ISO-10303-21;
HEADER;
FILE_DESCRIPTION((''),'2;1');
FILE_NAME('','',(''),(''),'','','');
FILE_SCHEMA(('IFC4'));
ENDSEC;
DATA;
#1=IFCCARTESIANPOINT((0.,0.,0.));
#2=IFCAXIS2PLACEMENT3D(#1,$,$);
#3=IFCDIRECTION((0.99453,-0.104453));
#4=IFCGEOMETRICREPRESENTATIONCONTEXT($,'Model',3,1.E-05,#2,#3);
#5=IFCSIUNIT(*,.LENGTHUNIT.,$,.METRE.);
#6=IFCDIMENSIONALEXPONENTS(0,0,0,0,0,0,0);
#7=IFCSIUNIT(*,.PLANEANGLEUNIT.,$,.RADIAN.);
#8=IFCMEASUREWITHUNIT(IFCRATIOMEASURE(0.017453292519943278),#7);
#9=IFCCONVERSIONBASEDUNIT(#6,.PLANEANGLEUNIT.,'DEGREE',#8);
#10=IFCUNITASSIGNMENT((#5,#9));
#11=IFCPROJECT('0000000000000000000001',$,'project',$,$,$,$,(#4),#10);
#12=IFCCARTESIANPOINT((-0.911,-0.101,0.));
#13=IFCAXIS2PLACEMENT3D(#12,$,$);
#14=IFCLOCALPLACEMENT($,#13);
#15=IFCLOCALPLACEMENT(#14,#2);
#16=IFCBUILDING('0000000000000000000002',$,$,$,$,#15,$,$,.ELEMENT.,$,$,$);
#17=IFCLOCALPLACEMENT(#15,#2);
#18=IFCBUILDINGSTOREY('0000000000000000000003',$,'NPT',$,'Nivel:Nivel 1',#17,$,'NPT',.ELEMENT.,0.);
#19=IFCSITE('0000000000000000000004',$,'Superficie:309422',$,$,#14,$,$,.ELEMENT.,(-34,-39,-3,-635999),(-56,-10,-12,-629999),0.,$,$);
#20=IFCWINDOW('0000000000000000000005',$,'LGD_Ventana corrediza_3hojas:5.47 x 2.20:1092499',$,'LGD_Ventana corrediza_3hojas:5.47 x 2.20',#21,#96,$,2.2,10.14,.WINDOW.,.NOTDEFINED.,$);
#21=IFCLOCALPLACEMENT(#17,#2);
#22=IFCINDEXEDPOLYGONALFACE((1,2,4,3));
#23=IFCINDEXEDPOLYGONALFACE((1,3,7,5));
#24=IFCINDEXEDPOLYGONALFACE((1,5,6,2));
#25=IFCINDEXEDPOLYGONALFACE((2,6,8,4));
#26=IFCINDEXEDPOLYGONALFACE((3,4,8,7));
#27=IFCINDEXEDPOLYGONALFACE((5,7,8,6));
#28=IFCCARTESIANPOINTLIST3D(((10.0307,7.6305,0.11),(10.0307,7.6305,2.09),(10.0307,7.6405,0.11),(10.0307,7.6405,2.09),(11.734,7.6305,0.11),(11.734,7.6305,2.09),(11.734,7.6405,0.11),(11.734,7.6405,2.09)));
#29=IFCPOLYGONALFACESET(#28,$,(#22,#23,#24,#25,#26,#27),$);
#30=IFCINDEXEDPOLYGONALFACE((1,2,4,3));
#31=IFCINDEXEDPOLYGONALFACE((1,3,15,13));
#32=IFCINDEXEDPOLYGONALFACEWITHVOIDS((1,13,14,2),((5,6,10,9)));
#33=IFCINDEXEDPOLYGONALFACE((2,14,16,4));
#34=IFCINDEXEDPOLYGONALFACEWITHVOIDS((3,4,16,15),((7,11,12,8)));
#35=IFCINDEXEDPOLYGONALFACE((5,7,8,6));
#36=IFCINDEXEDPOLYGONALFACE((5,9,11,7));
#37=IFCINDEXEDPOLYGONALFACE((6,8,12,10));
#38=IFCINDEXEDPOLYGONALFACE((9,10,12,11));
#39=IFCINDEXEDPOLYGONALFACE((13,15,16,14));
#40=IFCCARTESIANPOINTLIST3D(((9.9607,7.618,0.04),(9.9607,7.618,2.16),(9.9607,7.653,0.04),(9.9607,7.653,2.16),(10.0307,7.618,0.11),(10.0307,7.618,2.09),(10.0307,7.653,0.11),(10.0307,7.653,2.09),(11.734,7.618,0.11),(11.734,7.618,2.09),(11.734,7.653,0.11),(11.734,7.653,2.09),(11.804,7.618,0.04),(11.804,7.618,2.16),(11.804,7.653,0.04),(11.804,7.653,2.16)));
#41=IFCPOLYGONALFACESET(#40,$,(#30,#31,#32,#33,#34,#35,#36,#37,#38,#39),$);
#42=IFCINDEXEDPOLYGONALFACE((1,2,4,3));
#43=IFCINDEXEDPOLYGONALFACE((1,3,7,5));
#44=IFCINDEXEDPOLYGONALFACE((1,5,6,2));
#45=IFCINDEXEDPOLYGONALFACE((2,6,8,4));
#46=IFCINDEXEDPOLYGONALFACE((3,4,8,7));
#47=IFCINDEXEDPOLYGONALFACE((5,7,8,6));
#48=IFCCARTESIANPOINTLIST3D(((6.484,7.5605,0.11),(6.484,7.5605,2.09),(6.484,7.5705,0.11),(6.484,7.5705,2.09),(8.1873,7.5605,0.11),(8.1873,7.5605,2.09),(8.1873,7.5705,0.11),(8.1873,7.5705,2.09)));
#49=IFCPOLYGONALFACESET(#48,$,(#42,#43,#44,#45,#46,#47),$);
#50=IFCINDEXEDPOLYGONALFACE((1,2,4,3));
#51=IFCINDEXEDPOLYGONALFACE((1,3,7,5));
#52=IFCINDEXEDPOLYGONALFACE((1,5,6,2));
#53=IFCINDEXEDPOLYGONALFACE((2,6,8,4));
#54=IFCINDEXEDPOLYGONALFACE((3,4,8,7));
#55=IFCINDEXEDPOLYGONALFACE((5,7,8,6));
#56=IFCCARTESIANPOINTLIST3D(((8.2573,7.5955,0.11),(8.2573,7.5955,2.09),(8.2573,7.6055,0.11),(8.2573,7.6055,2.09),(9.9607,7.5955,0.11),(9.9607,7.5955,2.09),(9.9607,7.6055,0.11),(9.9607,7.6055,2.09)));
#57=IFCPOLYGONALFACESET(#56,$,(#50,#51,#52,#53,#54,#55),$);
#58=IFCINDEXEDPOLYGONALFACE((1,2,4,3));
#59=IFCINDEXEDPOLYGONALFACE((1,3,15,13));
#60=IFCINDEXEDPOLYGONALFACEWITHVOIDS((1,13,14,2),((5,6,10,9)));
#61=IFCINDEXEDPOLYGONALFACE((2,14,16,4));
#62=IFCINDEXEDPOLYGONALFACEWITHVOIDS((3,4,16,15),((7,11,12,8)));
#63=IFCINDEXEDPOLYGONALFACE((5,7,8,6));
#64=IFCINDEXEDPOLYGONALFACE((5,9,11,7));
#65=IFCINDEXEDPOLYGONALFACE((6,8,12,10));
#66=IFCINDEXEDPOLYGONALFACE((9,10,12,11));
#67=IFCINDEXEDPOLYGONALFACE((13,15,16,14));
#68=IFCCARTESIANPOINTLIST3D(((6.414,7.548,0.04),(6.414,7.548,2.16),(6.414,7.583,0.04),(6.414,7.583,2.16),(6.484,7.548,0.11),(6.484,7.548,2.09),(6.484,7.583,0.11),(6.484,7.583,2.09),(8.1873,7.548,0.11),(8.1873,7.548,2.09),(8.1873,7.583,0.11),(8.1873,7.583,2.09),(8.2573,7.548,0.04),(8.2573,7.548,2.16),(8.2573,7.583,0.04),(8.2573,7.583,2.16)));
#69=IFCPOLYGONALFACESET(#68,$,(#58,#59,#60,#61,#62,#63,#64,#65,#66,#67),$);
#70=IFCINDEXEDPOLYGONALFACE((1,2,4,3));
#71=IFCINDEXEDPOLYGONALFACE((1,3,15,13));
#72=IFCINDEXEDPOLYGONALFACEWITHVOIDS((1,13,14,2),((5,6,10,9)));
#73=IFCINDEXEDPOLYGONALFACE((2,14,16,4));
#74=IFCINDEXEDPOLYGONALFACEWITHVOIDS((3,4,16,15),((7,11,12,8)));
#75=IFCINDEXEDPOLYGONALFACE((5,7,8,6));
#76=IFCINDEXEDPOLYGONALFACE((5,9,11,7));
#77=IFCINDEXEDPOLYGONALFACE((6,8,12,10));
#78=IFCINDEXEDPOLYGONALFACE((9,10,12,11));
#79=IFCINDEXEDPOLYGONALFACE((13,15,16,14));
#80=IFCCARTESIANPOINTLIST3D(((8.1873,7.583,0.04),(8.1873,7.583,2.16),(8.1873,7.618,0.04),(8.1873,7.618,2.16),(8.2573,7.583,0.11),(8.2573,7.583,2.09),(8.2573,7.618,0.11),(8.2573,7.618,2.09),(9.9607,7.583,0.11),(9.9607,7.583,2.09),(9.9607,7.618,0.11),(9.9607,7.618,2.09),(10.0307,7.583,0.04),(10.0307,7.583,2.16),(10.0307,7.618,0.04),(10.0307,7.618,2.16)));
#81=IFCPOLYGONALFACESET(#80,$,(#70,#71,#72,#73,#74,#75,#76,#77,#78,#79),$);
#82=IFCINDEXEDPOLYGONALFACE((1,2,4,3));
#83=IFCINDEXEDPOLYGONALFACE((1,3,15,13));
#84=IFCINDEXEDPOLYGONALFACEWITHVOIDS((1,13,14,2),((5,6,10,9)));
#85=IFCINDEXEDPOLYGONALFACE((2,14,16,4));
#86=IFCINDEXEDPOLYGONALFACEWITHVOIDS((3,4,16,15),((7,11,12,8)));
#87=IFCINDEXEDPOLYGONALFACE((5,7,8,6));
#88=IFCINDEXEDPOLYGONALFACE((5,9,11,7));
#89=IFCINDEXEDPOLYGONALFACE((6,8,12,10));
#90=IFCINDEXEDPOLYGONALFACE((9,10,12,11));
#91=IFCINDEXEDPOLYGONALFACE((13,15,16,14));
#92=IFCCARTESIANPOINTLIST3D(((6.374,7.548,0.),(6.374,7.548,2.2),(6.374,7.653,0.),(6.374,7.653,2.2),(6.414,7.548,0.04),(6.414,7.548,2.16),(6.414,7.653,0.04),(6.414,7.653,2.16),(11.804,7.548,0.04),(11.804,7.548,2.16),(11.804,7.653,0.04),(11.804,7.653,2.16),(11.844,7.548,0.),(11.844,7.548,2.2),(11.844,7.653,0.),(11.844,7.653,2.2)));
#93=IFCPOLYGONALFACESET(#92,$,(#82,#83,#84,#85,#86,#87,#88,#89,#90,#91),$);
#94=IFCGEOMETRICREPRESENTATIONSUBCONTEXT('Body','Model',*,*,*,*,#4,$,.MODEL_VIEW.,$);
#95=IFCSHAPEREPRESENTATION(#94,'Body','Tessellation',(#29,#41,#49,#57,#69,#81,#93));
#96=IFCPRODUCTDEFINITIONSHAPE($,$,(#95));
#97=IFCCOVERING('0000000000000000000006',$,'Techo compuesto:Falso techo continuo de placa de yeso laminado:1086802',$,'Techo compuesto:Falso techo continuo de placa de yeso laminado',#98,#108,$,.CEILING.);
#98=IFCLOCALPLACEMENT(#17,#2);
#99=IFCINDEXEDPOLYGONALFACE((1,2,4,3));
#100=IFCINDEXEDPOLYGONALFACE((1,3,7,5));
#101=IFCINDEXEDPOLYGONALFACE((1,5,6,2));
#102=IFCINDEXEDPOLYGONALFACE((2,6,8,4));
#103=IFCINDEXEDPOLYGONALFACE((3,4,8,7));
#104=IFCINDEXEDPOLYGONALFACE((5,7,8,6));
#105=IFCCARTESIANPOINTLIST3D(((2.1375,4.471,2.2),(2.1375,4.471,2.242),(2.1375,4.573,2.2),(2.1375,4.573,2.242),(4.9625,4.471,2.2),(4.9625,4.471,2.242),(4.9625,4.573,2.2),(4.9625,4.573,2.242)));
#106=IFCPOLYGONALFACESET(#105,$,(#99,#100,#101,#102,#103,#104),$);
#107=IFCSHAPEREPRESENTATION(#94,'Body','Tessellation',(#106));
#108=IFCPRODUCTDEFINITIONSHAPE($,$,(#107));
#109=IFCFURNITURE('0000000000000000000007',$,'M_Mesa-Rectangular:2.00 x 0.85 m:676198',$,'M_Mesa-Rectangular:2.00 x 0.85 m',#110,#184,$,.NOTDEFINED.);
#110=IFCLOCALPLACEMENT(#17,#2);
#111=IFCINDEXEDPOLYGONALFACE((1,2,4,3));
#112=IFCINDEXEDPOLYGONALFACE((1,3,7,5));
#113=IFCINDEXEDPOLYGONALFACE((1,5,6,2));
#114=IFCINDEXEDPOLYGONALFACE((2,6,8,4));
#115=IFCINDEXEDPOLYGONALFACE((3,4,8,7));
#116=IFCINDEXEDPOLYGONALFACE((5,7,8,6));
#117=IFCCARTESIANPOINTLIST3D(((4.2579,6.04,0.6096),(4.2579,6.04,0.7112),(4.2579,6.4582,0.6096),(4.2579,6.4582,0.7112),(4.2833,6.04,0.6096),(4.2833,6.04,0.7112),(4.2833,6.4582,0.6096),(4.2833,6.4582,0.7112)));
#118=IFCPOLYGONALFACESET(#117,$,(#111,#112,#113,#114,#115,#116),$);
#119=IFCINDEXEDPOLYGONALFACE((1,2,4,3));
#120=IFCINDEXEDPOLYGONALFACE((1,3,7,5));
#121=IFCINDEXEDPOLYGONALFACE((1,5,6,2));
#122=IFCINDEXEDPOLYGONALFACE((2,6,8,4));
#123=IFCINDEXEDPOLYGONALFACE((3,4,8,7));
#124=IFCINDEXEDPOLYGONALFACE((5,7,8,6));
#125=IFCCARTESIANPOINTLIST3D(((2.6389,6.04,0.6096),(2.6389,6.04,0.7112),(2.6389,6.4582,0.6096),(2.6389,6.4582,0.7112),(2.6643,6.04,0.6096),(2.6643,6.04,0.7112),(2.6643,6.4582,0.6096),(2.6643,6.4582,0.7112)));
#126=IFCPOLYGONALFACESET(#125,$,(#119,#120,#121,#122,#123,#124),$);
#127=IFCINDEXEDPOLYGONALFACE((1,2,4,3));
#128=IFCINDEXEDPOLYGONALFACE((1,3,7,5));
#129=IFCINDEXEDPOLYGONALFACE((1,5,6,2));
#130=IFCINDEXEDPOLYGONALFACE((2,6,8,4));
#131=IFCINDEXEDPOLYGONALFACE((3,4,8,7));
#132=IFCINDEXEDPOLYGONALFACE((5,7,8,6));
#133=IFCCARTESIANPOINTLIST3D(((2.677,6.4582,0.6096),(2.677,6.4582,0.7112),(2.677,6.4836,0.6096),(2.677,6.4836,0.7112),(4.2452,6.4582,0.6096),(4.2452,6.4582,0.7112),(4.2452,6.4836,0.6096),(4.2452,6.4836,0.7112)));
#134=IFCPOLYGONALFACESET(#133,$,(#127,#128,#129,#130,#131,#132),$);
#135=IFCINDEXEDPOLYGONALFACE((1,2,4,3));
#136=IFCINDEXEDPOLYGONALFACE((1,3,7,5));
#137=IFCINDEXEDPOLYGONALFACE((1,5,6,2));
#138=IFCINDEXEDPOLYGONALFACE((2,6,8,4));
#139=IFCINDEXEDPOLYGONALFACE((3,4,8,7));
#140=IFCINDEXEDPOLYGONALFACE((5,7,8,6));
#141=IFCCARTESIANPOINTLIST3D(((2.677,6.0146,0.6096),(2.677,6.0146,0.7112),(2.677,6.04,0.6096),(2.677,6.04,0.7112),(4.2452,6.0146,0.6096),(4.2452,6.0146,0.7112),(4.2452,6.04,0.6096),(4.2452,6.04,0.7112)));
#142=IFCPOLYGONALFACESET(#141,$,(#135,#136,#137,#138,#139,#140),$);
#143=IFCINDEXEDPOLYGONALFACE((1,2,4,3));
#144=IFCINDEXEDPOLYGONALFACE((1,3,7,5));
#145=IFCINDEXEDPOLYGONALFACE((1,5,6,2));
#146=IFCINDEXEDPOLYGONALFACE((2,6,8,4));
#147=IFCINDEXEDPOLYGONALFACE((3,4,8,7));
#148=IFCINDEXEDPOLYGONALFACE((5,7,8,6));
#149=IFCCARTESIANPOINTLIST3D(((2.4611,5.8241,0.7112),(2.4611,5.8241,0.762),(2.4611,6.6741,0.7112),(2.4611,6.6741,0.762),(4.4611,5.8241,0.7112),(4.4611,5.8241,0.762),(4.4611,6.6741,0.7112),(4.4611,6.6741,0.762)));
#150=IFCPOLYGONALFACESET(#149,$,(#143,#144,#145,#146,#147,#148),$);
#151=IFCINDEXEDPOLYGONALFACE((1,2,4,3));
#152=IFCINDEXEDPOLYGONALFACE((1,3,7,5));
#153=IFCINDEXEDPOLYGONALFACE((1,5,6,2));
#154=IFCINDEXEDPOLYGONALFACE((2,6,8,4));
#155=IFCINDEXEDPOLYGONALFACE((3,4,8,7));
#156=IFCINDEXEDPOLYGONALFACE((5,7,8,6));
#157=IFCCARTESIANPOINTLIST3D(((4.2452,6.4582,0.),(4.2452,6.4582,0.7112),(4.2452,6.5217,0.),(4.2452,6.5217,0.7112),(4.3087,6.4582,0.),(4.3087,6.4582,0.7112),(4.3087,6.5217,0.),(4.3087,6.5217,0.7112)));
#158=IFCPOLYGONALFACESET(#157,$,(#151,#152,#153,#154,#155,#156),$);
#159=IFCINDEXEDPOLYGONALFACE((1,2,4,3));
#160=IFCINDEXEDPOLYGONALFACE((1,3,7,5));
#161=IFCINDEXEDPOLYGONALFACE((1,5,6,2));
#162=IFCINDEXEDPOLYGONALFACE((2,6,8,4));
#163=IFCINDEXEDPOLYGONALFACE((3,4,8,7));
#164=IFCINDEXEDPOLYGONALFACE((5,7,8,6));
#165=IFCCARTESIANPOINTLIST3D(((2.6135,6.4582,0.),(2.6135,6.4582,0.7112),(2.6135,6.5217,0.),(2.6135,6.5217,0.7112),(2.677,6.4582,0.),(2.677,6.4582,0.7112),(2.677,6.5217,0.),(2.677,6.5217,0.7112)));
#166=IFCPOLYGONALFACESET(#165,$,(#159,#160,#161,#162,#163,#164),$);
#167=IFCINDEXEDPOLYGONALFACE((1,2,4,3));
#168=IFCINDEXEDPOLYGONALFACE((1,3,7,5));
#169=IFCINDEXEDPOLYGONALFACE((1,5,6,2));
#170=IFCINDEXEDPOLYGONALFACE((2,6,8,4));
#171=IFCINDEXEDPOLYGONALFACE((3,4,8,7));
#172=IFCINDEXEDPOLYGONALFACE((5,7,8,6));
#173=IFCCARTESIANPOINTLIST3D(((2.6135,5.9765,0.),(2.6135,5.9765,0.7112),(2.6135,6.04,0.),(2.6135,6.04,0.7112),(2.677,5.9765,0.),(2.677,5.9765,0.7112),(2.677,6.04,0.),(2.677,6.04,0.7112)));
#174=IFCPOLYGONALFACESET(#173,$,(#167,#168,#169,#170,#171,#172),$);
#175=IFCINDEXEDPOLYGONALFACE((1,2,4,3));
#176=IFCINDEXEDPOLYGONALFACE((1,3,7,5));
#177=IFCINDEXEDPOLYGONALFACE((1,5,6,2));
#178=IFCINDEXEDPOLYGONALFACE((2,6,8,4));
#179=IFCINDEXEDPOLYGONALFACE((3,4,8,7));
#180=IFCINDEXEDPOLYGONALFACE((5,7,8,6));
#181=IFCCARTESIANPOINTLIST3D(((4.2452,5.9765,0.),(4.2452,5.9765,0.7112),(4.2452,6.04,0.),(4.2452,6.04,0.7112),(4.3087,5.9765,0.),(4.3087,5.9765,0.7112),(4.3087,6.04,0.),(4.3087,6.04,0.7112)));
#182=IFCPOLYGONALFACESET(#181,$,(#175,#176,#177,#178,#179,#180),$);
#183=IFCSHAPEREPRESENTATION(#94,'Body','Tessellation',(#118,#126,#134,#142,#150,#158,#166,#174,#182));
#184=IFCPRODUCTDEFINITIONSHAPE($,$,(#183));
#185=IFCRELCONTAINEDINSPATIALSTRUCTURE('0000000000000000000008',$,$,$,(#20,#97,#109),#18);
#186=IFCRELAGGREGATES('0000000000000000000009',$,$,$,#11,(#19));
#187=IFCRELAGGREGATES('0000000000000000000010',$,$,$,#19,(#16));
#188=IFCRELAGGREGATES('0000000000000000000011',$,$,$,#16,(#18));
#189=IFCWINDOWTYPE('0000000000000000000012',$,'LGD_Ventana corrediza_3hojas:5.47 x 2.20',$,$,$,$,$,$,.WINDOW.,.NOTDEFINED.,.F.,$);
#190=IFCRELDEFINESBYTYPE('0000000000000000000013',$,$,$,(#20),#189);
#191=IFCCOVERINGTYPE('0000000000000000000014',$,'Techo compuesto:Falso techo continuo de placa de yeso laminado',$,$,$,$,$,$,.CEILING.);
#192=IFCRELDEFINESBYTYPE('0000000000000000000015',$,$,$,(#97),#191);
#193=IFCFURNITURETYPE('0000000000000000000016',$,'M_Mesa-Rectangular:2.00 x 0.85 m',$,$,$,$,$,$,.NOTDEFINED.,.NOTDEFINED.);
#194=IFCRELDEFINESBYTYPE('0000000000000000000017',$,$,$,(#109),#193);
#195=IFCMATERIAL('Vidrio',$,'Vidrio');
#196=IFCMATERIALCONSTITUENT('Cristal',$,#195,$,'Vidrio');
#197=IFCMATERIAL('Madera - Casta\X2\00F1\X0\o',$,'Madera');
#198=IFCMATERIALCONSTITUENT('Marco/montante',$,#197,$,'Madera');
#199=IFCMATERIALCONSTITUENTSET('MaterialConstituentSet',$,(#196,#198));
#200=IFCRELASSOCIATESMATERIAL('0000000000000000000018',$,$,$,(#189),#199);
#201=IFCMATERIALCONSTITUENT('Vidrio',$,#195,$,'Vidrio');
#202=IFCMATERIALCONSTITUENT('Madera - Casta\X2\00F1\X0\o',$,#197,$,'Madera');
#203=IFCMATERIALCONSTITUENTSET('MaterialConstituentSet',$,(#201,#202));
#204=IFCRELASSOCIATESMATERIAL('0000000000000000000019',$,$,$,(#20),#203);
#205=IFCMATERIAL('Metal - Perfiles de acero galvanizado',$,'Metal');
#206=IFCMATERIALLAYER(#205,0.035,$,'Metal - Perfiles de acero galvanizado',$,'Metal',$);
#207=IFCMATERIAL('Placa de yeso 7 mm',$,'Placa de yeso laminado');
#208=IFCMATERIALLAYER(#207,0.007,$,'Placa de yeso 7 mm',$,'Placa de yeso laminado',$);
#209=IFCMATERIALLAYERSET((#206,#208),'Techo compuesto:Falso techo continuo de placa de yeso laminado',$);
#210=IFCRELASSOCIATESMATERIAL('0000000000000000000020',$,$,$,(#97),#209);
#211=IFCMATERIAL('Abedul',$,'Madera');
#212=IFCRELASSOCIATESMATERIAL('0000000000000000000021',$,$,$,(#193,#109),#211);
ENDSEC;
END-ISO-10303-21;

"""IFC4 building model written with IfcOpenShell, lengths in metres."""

from ifc_helpers import new_model, entity, si_unit, converted_unit, direction, frame, frame_2d, origin, origin_2d_with_axis, place, context, subcontext, project, spatial, polyline, rectangle, outline, extrude, source, transform, mapped, material, layer, layer_set, layer_usage, constituent, constituent_set, type_object, type_shapes, element, save


model = new_model("IFC4")

# Units and contexts
model_context = context("Model", 3, precision=1e-05, world=origin(), true_north=direction((0.99453, -0.104453)))
body_context = subcontext(model_context, "Body", "Model", "MODEL_VIEW")
ifc_project = project(units=[si_unit("LENGTHUNIT", "METRE"), converted_unit("PLANEANGLEUNIT", "DEGREE", entity("IfcRatioMeasure", 0.017453292519943278), si_unit("PLANEANGLEUNIT", "RADIAN"), dimensions=[0, 0, 0, 0, 0, 0, 0])], contexts=[model_context])

# Site, building, storey
site_placement = place(None, frame((-0.911, -0.101, 0.0)))
site = spatial("IfcSite", under=ifc_project, at=site_placement, Name="Superficie:309422", CompositionType="ELEMENT", RefLatitude=(-34, -39, -3, -635999), RefLongitude=(-56, -10, -12, -629999), RefElevation=0.0)
building_placement = place(site_placement, origin())
building = spatial("IfcBuilding", under=site, at=building_placement, CompositionType="ELEMENT")
storey_placement = place(building_placement, origin())
storey = spatial("IfcBuildingStorey", under=building, at=storey_placement, Name="NPT", ObjectType="Nivel:Nivel 1", LongName="NPT", CompositionType="ELEMENT", Elevation=0.0)

# Window
ifc_material_1 = material(Name="Vidrio", Category="Vidrio")
ifc_constituent_1 = constituent(ifc_material_1, Name="Vidrio", Category="Vidrio")
ifc_material_2 = material(Name="Madera - Castaño", Category="Madera")
ifc_constituent_2 = constituent(ifc_material_2, Name="Madera - Castaño", Category="Madera")
ifc_constituent_set_1 = constituent_set(constituents=[ifc_constituent_1, ifc_constituent_2], Name="MaterialConstituentSet")
ifc_constituent_3 = constituent(ifc_material_1, Name="Cristal", Category="Vidrio")
ifc_constituent_4 = constituent(ifc_material_2, Name="Marco/montante", Category="Madera")
ifc_constituent_set_2 = constituent_set(constituents=[ifc_constituent_3, ifc_constituent_4], Name="MaterialConstituentSet")
window_type_1 = type_object("IfcWindowType", Name="LGD_Ventana corrediza_3hojas:5.47 x 2.20", ParameterTakesPrecedence=False, PartitioningType="NOTDEFINED", PredefinedType="WINDOW", material=ifc_constituent_set_2)
shared_shape_1 = source(origin(), body_context, "Body", "SweptSolid", [
    extrude(rectangle(XDim=0.01, YDim=1.7033, at=frame_2d((0.0, 0.0), x_axis=(1.0, 0.0))), frame((6.2817, 0.2175, 0.11), z_axis=(0.0, 0.0, 1.0), x_axis=(0.0, -1.0, 0.0)), (0.0, 0.0, 1.0), 1.98),
    extrude(outline(polyline([(-0.9217, -1.06), (0.9217, -1.06), (0.9217, 1.06), (-0.9217, 1.06), (-0.9217, -1.06)]), holes=[polyline([(-0.8517, 0.99), (0.8517, 0.99), (0.8517, -0.99), (-0.8517, -0.99), (-0.8517, 0.99)])]), frame((6.2817, 0.235, 1.1), z_axis=(0.0, -1.0, 0.0), x_axis=(1.0, 0.0, 0.0)), (0.0, 0.0, 1.0), 0.035),
    extrude(rectangle(XDim=0.01, YDim=1.7033, at=frame_2d((0.0, 0.0), x_axis=(1.0, 0.0))), frame((2.735, 0.1475, 0.11), z_axis=(0.0, 0.0, 1.0), x_axis=(0.0, -1.0, 0.0)), (0.0, 0.0, 1.0), 1.98),
    extrude(rectangle(XDim=0.01, YDim=1.7033, at=frame_2d((0.0, 0.0), x_axis=(1.0, 0.0))), frame((4.5083, 0.1825, 0.11), z_axis=(0.0, 0.0, 1.0), x_axis=(0.0, -1.0, 0.0)), (0.0, 0.0, 1.0), 1.98),
    extrude(outline(polyline([(-0.9217, -1.06), (0.9217, -1.06), (0.9217, 1.06), (-0.9217, 1.06), (-0.9217, -1.06)]), holes=[polyline([(-0.8517, 0.99), (0.8517, 0.99), (0.8517, -0.99), (-0.8517, -0.99), (-0.8517, 0.99)])]), frame((2.735, 0.165, 1.1), z_axis=(0.0, -1.0, 0.0), x_axis=(1.0, 0.0, 0.0)), (0.0, 0.0, 1.0), 0.035),
    extrude(outline(polyline([(-0.9217, -1.06), (0.9217, -1.06), (0.9217, 1.06), (-0.9217, 1.06), (-0.9217, -1.06)]), holes=[polyline([(-0.8517, 0.99), (0.8517, 0.99), (0.8517, -0.99), (-0.8517, -0.99), (-0.8517, 0.99)])]), frame((4.5083, 0.2, 1.1), z_axis=(0.0, -1.0, 0.0), x_axis=(1.0, 0.0, 0.0)), (0.0, 0.0, 1.0), 0.035),
    extrude(outline(polyline([(-2.735, -1.1), (2.735, -1.1), (2.735, 1.1), (-2.735, 1.1), (-2.735, -1.1)]), holes=[polyline([(-2.695, 1.06), (2.695, 1.06), (2.695, -1.06), (-2.695, -1.06), (-2.695, 1.06)])]), frame((4.5083, 0.235, 1.1), z_axis=(0.0, -1.0, 0.0), x_axis=(1.0, 0.0, 0.0)), (0.0, 0.0, 1.0), 0.105),
])
type_shapes(window_type_1, [shared_shape_1])
window_1_placement = place(storey_placement, frame((4.6007, 7.418, 0.0)))
element("IfcWindow", 1, at=window_1_placement, inside=storey, type_object=window_type_1, material=ifc_constituent_set_1, Name="LGD_Ventana corrediza_3hojas:5.47 x 2.20:1092499", ObjectType="LGD_Ventana corrediza_3hojas:5.47 x 2.20", OverallHeight=2.2, OverallWidth=10.14, PartitioningType="NOTDEFINED", PredefinedType="WINDOW", context=body_context, shape_type="MappedRepresentation", body=[
    mapped(shared_shape_1, transform((0.0, 0.0, 0.0), scale=1.0)),
])

# Covering
ifc_material_3 = material(Name="Metal - Perfiles de acero galvanizado", Category="Metal")
ifc_layer_1 = layer(ifc_material_3, 0.035, Name="Metal - Perfiles de acero galvanizado", Category="Metal")
ifc_material_4 = material(Name="Placa de yeso 7 mm", Category="Placa de yeso laminado")
ifc_layer_2 = layer(ifc_material_4, 0.007, Name="Placa de yeso 7 mm", Category="Placa de yeso laminado")
ifc_layer_set_1 = layer_set([ifc_layer_1, ifc_layer_2], Name="Techo compuesto:Falso techo continuo de placa de yeso laminado")
ifc_layer_usage_1 = layer_usage(ifc_layer_set_1, "AXIS3", "POSITIVE", 0.0)
covering_type = type_object("IfcCoveringType", Name="Techo compuesto:Falso techo continuo de placa de yeso laminado", PredefinedType="CEILING")
covering_placement = place(storey_placement, frame((2.1375, 4.471, 2.2)))
element("IfcCovering", 2, at=covering_placement, inside=storey, type_object=covering_type, material=ifc_layer_usage_1, Name="Techo compuesto:Falso techo continuo de placa de yeso laminado:1086802", ObjectType="Techo compuesto:Falso techo continuo de placa de yeso laminado", PredefinedType="CEILING", context=body_context, shape_type="SweptSolid", body=[
    extrude(rectangle(XDim=2.825, YDim=0.102, at=frame_2d((0.0, 0.0), x_axis=(1.0, 0.0))), frame((1.4125, 0.051, 0.0), z_axis=(0.0, 0.0, 1.0), x_axis=(-1.0, 0.0, 0.0)), (0.0, 0.0, 1.0), 0.042),
])

# Furniture
ifc_material_5 = material(Name="Abedul", Category="Madera")
furniture_type_1 = type_object("IfcFurnitureType", Name="M_Mesa-Rectangular:2.00 x 0.85 m", AssemblyPlace="NOTDEFINED", PredefinedType="NOTDEFINED", material=ifc_material_5)
shared_shape_2 = source(origin(), body_context, "Body", "SweptSolid", [
    extrude(rectangle(XDim=0.0254, YDim=0.4182, at=origin_2d_with_axis()), frame((0.8095, 0.0, 0.6096)), (0.0, 0.0, 1.0), 0.1016),
    extrude(rectangle(XDim=0.4182, YDim=0.0254, at=origin_2d_with_axis()), frame((-0.8095, 0.0, 0.6096), z_axis=(0.0, 0.0, 1.0), x_axis=(0.0, 1.0, 0.0)), (0.0, 0.0, 1.0), 0.1016),
    extrude(rectangle(XDim=1.5682, YDim=0.0254, at=frame_2d((0.0, 0.0), x_axis=(1.0, 0.0))), frame((0.0, 0.2218, 0.6096), z_axis=(0.0, 0.0, 1.0), x_axis=(-1.0, 0.0, 0.0)), (0.0, 0.0, 1.0), 0.1016),
    extrude(rectangle(XDim=0.0254, YDim=1.5682, at=origin_2d_with_axis()), frame((0.0, -0.2218, 0.6096), z_axis=(0.0, 0.0, 1.0), x_axis=(0.0, 1.0, 0.0)), (0.0, 0.0, 1.0), 0.1016),
    extrude(rectangle(XDim=2.0, YDim=0.85, at=origin_2d_with_axis()), frame((0.0, 0.0, 0.7112), z_axis=(0.0, 0.0, 1.0), x_axis=(-1.0, 0.0, 0.0)), (0.0, 0.0, 1.0), 0.0508),
    extrude(rectangle(XDim=0.0635, YDim=0.0635, at=origin_2d_with_axis()), frame((0.8158, 0.2409, 0.0), z_axis=(0.0, 0.0, 1.0), x_axis=(0.0, -1.0, 0.0)), (0.0, 0.0, 1.0), 0.7112),
    extrude(rectangle(XDim=0.0635, YDim=0.0635, at=frame_2d((0.0, 0.0), x_axis=(1.0, 0.0))), frame((-0.8158, 0.2409, 0.0), z_axis=(0.0, 0.0, 1.0), x_axis=(-1.0, 0.0, 0.0)), (0.0, 0.0, 1.0), 0.7112),
    extrude(rectangle(XDim=0.0635, YDim=0.0635, at=frame_2d((0.0, 0.0), x_axis=(1.0, 0.0))), frame((-0.8158, -0.2409, 0.0), z_axis=(0.0, 0.0, 1.0), x_axis=(0.0, 1.0, 0.0)), (0.0, 0.0, 1.0), 0.7112),
    extrude(rectangle(XDim=0.0635, YDim=0.0635, at=origin_2d_with_axis()), frame((0.8158, -0.2409, 0.0)), (0.0, 0.0, 1.0), 0.7112),
])
type_shapes(furniture_type_1, [shared_shape_2])
furniture_1_placement = place(storey_placement, frame((3.4611, 6.2491, 0.0)))
element("IfcFurniture", 3, at=furniture_1_placement, inside=storey, type_object=furniture_type_1, material=ifc_material_5, Name="M_Mesa-Rectangular:2.00 x 0.85 m:676198", ObjectType="M_Mesa-Rectangular:2.00 x 0.85 m", PredefinedType="NOTDEFINED", context=body_context, shape_type="MappedRepresentation", body=[
    mapped(shared_shape_2, transform((0.0, 0.0, 0.0), scale=1.0)),
])

save(model, "model.ifc")
